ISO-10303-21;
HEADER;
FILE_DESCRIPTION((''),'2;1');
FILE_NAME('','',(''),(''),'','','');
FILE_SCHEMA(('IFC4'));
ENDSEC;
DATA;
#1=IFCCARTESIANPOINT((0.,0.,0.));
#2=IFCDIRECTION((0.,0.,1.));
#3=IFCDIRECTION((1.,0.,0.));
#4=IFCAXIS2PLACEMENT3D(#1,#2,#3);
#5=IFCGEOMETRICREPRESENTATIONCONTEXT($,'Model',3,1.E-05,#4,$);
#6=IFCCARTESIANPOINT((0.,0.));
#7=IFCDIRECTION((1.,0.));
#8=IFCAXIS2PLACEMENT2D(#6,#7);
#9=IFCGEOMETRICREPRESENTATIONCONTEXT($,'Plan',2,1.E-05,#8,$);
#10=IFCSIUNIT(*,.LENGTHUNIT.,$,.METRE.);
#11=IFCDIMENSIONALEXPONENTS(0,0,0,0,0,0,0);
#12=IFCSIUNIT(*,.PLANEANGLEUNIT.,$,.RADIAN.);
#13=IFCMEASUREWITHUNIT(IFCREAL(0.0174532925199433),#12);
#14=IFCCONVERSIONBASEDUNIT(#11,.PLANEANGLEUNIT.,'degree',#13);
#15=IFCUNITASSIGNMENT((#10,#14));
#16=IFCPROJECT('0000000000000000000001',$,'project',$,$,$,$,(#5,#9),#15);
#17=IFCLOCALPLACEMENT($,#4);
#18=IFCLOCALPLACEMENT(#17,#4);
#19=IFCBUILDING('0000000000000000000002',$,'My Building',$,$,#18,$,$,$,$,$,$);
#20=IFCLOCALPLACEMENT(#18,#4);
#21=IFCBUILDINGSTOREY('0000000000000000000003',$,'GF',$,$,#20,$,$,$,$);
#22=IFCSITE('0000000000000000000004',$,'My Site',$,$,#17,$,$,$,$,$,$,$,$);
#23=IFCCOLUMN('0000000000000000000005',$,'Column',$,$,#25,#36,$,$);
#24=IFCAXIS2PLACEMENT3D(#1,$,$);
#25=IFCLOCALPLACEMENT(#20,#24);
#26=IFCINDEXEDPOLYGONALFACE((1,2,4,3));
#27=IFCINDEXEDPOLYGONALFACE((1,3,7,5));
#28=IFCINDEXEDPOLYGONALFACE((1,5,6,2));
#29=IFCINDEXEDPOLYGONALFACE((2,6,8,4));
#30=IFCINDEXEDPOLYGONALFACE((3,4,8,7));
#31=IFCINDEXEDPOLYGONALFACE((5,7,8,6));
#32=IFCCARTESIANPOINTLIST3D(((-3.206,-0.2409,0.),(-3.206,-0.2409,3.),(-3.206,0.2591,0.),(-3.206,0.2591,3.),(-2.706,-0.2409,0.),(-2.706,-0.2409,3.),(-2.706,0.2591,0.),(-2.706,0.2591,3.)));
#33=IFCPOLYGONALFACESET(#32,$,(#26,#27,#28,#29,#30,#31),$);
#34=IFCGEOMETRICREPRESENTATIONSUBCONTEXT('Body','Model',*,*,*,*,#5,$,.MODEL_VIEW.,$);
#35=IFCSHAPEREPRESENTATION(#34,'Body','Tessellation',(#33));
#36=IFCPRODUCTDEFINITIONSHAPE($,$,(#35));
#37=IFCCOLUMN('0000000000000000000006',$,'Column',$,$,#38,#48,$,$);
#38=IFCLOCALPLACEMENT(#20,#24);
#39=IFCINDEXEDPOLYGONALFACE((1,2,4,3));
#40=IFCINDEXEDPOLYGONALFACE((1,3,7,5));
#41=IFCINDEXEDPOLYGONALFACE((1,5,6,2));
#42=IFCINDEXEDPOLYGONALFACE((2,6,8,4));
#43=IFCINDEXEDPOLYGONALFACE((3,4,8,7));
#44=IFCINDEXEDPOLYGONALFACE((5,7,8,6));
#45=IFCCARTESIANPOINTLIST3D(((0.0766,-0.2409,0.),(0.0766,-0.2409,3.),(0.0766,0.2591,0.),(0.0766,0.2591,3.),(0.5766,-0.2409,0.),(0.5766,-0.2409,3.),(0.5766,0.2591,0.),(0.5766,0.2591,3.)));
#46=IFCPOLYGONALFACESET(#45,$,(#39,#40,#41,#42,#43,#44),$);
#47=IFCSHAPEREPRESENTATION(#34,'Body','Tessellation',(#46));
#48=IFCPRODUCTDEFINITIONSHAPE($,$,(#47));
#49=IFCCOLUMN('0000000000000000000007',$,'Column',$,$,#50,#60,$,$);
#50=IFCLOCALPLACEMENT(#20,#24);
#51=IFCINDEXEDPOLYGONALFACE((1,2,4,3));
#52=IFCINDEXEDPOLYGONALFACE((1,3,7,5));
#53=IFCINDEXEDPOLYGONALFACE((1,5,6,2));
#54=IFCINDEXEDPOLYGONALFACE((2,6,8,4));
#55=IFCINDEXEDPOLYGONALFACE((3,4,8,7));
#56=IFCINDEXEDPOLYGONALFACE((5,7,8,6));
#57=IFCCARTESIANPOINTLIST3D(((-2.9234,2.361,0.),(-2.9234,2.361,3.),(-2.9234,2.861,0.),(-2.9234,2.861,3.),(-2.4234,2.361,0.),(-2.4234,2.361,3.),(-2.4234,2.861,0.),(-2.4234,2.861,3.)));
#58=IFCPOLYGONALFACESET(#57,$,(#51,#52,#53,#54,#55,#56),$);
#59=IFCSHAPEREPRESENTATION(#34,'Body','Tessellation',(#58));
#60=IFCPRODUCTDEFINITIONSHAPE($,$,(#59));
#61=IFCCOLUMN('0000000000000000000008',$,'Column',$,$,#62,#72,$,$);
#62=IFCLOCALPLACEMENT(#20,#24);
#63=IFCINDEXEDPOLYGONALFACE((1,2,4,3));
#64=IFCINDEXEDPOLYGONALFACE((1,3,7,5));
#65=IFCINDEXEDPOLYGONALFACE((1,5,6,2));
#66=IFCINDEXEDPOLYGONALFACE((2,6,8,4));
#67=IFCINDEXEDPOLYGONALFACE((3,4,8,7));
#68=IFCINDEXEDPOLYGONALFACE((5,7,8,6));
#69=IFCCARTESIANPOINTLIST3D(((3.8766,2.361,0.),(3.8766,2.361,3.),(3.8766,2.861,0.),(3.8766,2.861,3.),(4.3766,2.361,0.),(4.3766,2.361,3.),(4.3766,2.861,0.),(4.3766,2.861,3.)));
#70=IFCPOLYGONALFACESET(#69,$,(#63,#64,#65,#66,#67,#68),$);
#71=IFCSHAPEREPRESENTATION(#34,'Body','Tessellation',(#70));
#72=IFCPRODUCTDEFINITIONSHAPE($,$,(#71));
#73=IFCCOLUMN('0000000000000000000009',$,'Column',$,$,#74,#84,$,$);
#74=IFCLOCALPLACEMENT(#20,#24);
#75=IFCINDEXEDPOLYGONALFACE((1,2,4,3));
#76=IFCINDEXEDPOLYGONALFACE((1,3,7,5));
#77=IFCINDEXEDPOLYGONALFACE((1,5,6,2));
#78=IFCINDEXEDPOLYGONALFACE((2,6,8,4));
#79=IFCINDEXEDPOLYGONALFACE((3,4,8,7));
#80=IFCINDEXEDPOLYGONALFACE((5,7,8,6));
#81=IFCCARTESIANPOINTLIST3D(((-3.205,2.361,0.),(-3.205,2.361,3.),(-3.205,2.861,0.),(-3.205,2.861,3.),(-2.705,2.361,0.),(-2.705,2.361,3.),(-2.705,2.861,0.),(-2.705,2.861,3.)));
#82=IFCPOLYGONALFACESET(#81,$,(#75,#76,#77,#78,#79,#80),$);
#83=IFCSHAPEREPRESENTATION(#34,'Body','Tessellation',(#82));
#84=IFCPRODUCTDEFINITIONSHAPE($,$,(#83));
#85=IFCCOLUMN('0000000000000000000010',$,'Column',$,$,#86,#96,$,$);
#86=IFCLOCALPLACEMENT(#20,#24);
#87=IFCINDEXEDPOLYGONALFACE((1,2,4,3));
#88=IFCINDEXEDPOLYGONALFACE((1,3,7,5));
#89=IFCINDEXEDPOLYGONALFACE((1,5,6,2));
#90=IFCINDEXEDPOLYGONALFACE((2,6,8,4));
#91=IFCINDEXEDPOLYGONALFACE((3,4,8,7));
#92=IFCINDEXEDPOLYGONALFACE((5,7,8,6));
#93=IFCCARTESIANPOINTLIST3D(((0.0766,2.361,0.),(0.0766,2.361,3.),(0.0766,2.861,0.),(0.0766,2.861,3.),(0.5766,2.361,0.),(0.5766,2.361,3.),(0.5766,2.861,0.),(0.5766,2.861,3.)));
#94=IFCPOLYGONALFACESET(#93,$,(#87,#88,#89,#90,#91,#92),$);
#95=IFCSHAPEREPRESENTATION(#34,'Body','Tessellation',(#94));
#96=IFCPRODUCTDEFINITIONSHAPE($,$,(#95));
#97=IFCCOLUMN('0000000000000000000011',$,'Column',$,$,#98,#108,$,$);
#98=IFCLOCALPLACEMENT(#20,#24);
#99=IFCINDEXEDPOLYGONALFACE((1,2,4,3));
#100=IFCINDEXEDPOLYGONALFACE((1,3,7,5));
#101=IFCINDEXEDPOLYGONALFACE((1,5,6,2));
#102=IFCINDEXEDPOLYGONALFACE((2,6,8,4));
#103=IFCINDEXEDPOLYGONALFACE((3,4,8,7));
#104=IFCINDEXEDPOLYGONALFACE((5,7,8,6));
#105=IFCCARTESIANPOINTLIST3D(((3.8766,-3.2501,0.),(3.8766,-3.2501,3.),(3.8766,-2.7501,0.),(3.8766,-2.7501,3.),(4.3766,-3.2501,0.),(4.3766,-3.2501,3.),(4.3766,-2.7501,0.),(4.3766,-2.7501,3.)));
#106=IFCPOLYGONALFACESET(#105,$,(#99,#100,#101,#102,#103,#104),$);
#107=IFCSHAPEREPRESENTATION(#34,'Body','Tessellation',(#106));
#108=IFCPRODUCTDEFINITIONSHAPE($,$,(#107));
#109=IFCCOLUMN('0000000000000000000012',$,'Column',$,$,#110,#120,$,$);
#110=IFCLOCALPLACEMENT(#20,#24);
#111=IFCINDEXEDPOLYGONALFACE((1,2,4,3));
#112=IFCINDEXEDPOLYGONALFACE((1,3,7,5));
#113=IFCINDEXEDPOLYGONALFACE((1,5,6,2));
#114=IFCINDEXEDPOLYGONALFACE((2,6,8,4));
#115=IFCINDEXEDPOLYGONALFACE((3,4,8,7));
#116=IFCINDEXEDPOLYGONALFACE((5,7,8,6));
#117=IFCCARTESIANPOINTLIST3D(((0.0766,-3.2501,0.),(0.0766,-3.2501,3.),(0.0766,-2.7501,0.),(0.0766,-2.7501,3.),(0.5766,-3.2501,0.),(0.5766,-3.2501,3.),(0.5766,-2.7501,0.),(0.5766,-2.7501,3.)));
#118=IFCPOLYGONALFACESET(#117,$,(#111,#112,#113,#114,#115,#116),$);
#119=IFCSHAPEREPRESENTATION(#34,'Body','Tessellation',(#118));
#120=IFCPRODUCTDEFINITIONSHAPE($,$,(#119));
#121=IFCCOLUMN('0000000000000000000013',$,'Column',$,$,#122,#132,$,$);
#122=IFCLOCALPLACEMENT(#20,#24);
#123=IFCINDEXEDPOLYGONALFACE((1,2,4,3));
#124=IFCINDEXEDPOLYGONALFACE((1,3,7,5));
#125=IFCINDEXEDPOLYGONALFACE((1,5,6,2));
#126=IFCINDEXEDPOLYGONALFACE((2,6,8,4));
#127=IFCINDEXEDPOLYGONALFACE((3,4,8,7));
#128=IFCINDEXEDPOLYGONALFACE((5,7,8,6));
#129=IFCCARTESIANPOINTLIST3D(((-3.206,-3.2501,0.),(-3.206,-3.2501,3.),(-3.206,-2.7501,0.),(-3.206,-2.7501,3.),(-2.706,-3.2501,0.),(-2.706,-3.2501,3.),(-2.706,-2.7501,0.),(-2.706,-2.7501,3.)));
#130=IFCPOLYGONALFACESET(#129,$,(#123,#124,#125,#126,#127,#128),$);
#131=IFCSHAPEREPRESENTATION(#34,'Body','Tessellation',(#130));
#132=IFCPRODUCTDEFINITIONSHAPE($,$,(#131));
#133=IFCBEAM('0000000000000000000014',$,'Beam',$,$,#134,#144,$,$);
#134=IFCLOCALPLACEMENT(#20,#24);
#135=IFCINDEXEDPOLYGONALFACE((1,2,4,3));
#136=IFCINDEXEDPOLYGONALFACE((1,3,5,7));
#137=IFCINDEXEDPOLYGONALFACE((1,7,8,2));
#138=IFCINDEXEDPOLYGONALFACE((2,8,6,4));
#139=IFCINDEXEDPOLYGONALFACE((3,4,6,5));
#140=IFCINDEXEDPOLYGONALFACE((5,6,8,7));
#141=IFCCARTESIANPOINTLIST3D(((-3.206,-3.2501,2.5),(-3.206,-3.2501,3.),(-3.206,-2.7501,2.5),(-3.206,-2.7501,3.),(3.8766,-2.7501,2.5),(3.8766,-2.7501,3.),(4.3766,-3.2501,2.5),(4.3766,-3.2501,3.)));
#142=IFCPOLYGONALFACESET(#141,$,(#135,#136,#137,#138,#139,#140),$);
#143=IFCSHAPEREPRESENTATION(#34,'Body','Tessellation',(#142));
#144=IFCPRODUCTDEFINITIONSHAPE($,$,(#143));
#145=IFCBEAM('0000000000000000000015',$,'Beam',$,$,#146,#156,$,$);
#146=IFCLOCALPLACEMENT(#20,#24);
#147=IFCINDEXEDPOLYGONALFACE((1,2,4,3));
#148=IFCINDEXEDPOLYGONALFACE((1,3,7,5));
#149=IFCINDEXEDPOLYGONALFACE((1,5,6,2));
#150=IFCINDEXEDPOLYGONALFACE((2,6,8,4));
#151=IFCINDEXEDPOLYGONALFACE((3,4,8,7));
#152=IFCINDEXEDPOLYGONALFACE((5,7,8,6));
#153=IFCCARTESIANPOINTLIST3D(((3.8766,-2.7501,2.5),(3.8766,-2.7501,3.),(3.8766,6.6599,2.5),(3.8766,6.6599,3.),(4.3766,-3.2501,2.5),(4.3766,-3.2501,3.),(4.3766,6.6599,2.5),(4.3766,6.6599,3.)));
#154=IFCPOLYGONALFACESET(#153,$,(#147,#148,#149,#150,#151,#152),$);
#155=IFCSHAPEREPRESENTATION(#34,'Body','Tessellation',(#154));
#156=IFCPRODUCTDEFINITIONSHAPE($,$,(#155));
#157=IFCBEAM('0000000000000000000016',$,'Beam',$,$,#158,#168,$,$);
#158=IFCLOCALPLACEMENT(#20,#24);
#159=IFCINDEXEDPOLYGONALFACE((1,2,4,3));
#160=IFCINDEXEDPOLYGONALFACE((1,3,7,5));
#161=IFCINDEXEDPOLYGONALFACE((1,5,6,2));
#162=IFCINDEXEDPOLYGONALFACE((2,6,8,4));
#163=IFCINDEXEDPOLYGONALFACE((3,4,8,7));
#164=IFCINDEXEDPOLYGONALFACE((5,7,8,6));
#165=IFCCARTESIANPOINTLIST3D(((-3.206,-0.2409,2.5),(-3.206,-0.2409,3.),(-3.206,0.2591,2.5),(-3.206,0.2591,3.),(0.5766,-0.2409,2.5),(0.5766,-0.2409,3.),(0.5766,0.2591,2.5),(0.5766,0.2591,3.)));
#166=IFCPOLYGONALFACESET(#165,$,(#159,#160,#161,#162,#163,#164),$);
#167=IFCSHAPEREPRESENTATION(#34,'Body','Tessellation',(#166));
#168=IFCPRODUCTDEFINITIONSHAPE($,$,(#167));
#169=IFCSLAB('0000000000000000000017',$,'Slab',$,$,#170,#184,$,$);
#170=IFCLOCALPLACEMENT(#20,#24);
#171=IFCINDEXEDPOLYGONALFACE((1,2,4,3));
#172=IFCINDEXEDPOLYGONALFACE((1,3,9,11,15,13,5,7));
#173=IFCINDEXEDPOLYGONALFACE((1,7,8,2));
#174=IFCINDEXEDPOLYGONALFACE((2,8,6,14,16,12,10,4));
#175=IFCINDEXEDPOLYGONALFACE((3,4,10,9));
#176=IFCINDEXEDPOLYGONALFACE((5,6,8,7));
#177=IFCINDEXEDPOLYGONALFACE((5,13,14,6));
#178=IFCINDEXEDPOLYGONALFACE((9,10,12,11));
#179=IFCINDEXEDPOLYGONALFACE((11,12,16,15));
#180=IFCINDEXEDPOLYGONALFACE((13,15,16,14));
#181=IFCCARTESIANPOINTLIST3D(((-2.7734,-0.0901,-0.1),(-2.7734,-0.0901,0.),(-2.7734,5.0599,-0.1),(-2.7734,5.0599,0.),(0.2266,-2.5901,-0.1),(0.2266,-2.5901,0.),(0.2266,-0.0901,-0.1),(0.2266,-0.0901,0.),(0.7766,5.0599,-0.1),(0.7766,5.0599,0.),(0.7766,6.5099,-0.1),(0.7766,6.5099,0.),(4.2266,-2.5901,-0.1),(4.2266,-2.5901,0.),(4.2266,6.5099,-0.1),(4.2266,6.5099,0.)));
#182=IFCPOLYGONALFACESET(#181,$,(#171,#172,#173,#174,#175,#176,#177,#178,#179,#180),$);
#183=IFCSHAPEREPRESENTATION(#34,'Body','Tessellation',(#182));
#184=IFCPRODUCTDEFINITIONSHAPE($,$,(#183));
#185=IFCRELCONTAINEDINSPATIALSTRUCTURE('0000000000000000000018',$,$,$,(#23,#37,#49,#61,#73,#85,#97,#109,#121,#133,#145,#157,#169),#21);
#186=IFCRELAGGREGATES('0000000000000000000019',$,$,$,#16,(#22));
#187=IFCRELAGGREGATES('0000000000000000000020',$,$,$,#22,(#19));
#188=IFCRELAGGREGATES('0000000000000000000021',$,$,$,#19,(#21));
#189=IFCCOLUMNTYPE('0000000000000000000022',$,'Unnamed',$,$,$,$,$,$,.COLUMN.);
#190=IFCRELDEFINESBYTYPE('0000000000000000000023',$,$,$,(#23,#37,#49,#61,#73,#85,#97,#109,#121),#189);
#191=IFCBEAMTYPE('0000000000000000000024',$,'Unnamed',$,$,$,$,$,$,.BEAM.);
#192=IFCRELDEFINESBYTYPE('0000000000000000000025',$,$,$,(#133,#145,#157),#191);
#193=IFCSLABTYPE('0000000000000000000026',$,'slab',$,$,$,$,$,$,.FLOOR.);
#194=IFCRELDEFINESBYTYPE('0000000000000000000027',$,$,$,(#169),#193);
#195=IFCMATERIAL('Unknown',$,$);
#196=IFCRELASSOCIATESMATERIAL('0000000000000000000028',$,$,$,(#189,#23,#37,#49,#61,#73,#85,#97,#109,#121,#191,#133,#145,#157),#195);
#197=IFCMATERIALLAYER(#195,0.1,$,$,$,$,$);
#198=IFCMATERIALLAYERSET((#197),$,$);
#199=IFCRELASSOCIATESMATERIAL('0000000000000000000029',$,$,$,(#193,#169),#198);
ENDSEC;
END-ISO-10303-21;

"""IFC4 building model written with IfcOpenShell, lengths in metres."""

from ifc_helpers import new_model, entity, si_unit, converted_unit, frame, origin_with_axes, origin_2d_with_axis, place, context, subcontext, project, spatial, indexed_curve, rectangle, outline, extrude, clip, halfspace, material, layer, layer_set, layer_usage, material_profile, profile_set, profile_usage, type_object, element, save


model = new_model("IFC4")

# Units and contexts
model_context = context("Model", 3, precision=1e-05, world=origin_with_axes())
plan_context = context("Plan", 2, precision=1e-05, world=origin_2d_with_axis())
body_context_1 = subcontext(model_context, "Body", "Model", "MODEL_VIEW")
ifc_project = project(units=[si_unit("LENGTHUNIT", "METRE"), converted_unit("PLANEANGLEUNIT", "degree", entity("IfcReal", 0.0174532925199433), si_unit("PLANEANGLEUNIT", "RADIAN"), dimensions=[0, 0, 0, 0, 0, 0, 0])], contexts=[model_context, plan_context])

# Site, building, storey
site_placement = place(None, origin_with_axes())
site = spatial("IfcSite", under=ifc_project, at=site_placement, Name="My Site")
building_placement = place(site_placement, origin_with_axes())
building = spatial("IfcBuilding", under=site, at=building_placement, Name="My Building")
storey_placement = place(building_placement, origin_with_axes())
storey = spatial("IfcBuildingStorey", under=building, at=storey_placement, Name="GF")

# Columns
ifc_material = material(Name="Unknown")
ifc_material_profile_1 = material_profile(ifc_material, rectangle(XDim=0.5, YDim=0.5))
ifc_profile_set_1 = profile_set([ifc_material_profile_1])
ifc_profile_usage_1 = profile_usage(ifc_profile_set_1, cardinal=5)
column_type = type_object("IfcColumnType", Name="Unnamed", PredefinedType="COLUMN", material=ifc_profile_set_1)
column_1_placement = place(storey_placement, frame((-2.956, 0.0091, 0.0), z_axis=(0.0, 0.0, 1.0), x_axis=(1.0, 0.0, 0.0)))
element("IfcColumn", 1, at=column_1_placement, inside=storey, type_object=column_type, material=ifc_profile_usage_1, Name="Column", context=body_context_1, shape_type="SweptSolid", body=[
    extrude(rectangle(XDim=0.5, YDim=0.5), origin_with_axes(), (0.0, 0.0, 1.0), 3.0),
])
ifc_profile_usage_2 = profile_usage(ifc_profile_set_1, cardinal=5)
column_2_placement = place(storey_placement, frame((0.3266, 0.0091, 0.0), z_axis=(0.0, 0.0, 1.0), x_axis=(1.0, 0.0, 0.0)))
element("IfcColumn", 2, at=column_2_placement, inside=storey, type_object=column_type, material=ifc_profile_usage_2, Name="Column", context=body_context_1, shape_type="SweptSolid", body=[
    extrude(rectangle(XDim=0.5, YDim=0.5), origin_with_axes(), (0.0, 0.0, 1.0), 3.0),
])
ifc_profile_usage_3 = profile_usage(ifc_profile_set_1, cardinal=5)
column_3_placement = place(storey_placement, frame((-2.6734, 2.611, 0.0), z_axis=(0.0, 0.0, 1.0), x_axis=(1.0, 0.0, 0.0)))
element("IfcColumn", 3, at=column_3_placement, inside=storey, type_object=column_type, material=ifc_profile_usage_3, Name="Column", context=body_context_1, shape_type="SweptSolid", body=[
    extrude(rectangle(XDim=0.5, YDim=0.5), origin_with_axes(), (0.0, 0.0, 1.0), 3.0),
])
ifc_profile_usage_4 = profile_usage(ifc_profile_set_1, cardinal=5)
column_4_placement = place(storey_placement, frame((4.1266, 2.611, 0.0), z_axis=(0.0, 0.0, 1.0), x_axis=(1.0, 0.0, 0.0)))
element("IfcColumn", 4, at=column_4_placement, inside=storey, type_object=column_type, material=ifc_profile_usage_4, Name="Column", context=body_context_1, shape_type="SweptSolid", body=[
    extrude(rectangle(XDim=0.5, YDim=0.5), origin_with_axes(), (0.0, 0.0, 1.0), 3.0),
])
ifc_profile_usage_5 = profile_usage(ifc_profile_set_1, cardinal=5)
column_5_placement = place(storey_placement, frame((-2.955, 2.611, 0.0), z_axis=(0.0, 0.0, 1.0), x_axis=(1.0, 0.0, 0.0)))
element("IfcColumn", 5, at=column_5_placement, inside=storey, type_object=column_type, material=ifc_profile_usage_5, Name="Column", context=body_context_1, shape_type="SweptSolid", body=[
    extrude(rectangle(XDim=0.5, YDim=0.5), origin_with_axes(), (0.0, 0.0, 1.0), 3.0),
])
ifc_profile_usage_6 = profile_usage(ifc_profile_set_1, cardinal=5)
column_6_placement = place(storey_placement, frame((0.3266, 2.611, 0.0), z_axis=(0.0, 0.0, 1.0), x_axis=(1.0, 0.0, 0.0)))
element("IfcColumn", 6, at=column_6_placement, inside=storey, type_object=column_type, material=ifc_profile_usage_6, Name="Column", context=body_context_1, shape_type="SweptSolid", body=[
    extrude(rectangle(XDim=0.5, YDim=0.5), origin_with_axes(), (0.0, 0.0, 1.0), 3.0),
])
ifc_profile_usage_7 = profile_usage(ifc_profile_set_1, cardinal=5)
column_7_placement = place(storey_placement, frame((4.1266, -3.0001, 0.0), z_axis=(0.0, 0.0, 1.0), x_axis=(1.0, 0.0, 0.0)))
element("IfcColumn", 7, at=column_7_placement, inside=storey, type_object=column_type, material=ifc_profile_usage_7, Name="Column", context=body_context_1, shape_type="SweptSolid", body=[
    extrude(rectangle(XDim=0.5, YDim=0.5), origin_with_axes(), (0.0, 0.0, 1.0), 3.0),
])
ifc_profile_usage_8 = profile_usage(ifc_profile_set_1, cardinal=5)
column_8_placement = place(storey_placement, frame((0.3266, -3.0001, 0.0), z_axis=(0.0, 0.0, 1.0), x_axis=(1.0, 0.0, 0.0)))
element("IfcColumn", 8, at=column_8_placement, inside=storey, type_object=column_type, material=ifc_profile_usage_8, Name="Column", context=body_context_1, shape_type="SweptSolid", body=[
    extrude(rectangle(XDim=0.5, YDim=0.5), origin_with_axes(), (0.0, 0.0, 1.0), 3.0),
])
ifc_profile_usage_9 = profile_usage(ifc_profile_set_1, cardinal=5)
column_9_placement = place(storey_placement, frame((-2.956, -3.0001, 0.0), z_axis=(0.0, 0.0, 1.0), x_axis=(1.0, 0.0, 0.0)))
element("IfcColumn", 9, at=column_9_placement, inside=storey, type_object=column_type, material=ifc_profile_usage_9, Name="Column", context=body_context_1, shape_type="SweptSolid", body=[
    extrude(rectangle(XDim=0.5, YDim=0.5), origin_with_axes(), (0.0, 0.0, 1.0), 3.0),
])

# Beams
ifc_material_profile_2 = material_profile(ifc_material, rectangle(XDim=0.5, YDim=0.5))
ifc_profile_set_2 = profile_set([ifc_material_profile_2])
ifc_profile_usage_10 = profile_usage(ifc_profile_set_2, cardinal=9)
beam_type = type_object("IfcBeamType", Name="Unnamed", PredefinedType="BEAM", material=ifc_profile_set_2)
beam_1_placement = place(storey_placement, frame((-3.206, -3.2501, 3.0), z_axis=(1.0, 0.0, 0.0), x_axis=(0.0, 1.0, 0.0)))
element("IfcBeam", 10, at=beam_1_placement, inside=storey, type_object=beam_type, material=ifc_profile_usage_10, Name="Beam", context=body_context_1, shape_type="Clipping", body=[
    clip(extrude(rectangle(XDim=0.5, YDim=0.5), frame((0.25, -0.25, 0.0), z_axis=(0.0, 0.0, 1.0), x_axis=(1.0, 0.0, 0.0)), (0.0, 0.0, 1.0), 7.5826), halfspace(frame((0.0, -3.0, 7.5826), z_axis=(0.707106, 0.0, 0.707108), x_axis=(0.0, -1.0, 0.0)), False)),
])
ifc_profile_usage_11 = profile_usage(ifc_profile_set_2, cardinal=9)
beam_2_placement = place(storey_placement, frame((4.3766, -3.2501, 3.0), z_axis=(0.000003, 1.0, 0.0), x_axis=(-1.0, 0.000003, 0.0)))
element("IfcBeam", 11, at=beam_2_placement, inside=storey, type_object=beam_type, material=ifc_profile_usage_11, Name="Beam", context=body_context_1, shape_type="Clipping", body=[
    clip(extrude(rectangle(XDim=0.5, YDim=0.5), frame((0.25, -0.25, 0.0), z_axis=(0.0, 0.0, 1.0), x_axis=(1.0, 0.0, 0.0)), (0.0, 0.0, 1.0), 9.91), halfspace(frame((0.0, -3.0, 0.0), z_axis=(0.707106, 0.0, -0.707107), x_axis=(0.0, -1.0, 0.0)), False)),
])
ifc_profile_usage_12 = profile_usage(ifc_profile_set_2, cardinal=7)
beam_3_placement = place(storey_placement, frame((-3.206, 0.2591, 3.0), z_axis=(1.0, 0.0, 0.0), x_axis=(0.0, 1.0, 0.0)))
element("IfcBeam", 12, at=beam_3_placement, inside=storey, type_object=beam_type, material=ifc_profile_usage_12, Name="Beam", context=body_context_1, shape_type="SweptSolid", body=[
    extrude(rectangle(XDim=0.5, YDim=0.5), frame((-0.25, -0.25, 0.0), z_axis=(0.0, 0.0, 1.0), x_axis=(1.0, 0.0, 0.0)), (0.0, 0.0, 1.0), 3.7827),
])

# Slab
ifc_layer_1 = layer(ifc_material, 0.1)
ifc_layer_set_1 = layer_set([ifc_layer_1])
ifc_layer_usage_1 = layer_usage(ifc_layer_set_1, "AXIS3", "POSITIVE", -0.1)
slab_type_1 = type_object("IfcSlabType", Name="slab", PredefinedType="FLOOR", material=ifc_layer_set_1)
slab_1_placement = place(storey_placement, frame((4.2266, -2.5901, 0.0), z_axis=(0.0, 0.0, 1.0), x_axis=(1.0, 0.0, 0.0)))
element("IfcSlab", 13, at=slab_1_placement, inside=storey, type_object=slab_type_1, material=ifc_layer_usage_1, Name="Slab", context=body_context_1, shape_type="SweptSolid", body=[
    extrude(outline(indexed_curve([(0.0, 0.0), (0.0, 9.1), (-3.45, 9.1), (-3.45, 7.65), (-7.0, 7.65), (-7.0, 2.5), (-4.0, 2.5), (-4.0, 0.0), (0.0, 0.0)])), frame((0.0, 0.0, -0.1), z_axis=(0.0, 0.0, 1.0), x_axis=(1.0, 0.0, 0.0)), (0.0, 0.0, 1.0), 0.1),
])

save(model, "model.ifc")
